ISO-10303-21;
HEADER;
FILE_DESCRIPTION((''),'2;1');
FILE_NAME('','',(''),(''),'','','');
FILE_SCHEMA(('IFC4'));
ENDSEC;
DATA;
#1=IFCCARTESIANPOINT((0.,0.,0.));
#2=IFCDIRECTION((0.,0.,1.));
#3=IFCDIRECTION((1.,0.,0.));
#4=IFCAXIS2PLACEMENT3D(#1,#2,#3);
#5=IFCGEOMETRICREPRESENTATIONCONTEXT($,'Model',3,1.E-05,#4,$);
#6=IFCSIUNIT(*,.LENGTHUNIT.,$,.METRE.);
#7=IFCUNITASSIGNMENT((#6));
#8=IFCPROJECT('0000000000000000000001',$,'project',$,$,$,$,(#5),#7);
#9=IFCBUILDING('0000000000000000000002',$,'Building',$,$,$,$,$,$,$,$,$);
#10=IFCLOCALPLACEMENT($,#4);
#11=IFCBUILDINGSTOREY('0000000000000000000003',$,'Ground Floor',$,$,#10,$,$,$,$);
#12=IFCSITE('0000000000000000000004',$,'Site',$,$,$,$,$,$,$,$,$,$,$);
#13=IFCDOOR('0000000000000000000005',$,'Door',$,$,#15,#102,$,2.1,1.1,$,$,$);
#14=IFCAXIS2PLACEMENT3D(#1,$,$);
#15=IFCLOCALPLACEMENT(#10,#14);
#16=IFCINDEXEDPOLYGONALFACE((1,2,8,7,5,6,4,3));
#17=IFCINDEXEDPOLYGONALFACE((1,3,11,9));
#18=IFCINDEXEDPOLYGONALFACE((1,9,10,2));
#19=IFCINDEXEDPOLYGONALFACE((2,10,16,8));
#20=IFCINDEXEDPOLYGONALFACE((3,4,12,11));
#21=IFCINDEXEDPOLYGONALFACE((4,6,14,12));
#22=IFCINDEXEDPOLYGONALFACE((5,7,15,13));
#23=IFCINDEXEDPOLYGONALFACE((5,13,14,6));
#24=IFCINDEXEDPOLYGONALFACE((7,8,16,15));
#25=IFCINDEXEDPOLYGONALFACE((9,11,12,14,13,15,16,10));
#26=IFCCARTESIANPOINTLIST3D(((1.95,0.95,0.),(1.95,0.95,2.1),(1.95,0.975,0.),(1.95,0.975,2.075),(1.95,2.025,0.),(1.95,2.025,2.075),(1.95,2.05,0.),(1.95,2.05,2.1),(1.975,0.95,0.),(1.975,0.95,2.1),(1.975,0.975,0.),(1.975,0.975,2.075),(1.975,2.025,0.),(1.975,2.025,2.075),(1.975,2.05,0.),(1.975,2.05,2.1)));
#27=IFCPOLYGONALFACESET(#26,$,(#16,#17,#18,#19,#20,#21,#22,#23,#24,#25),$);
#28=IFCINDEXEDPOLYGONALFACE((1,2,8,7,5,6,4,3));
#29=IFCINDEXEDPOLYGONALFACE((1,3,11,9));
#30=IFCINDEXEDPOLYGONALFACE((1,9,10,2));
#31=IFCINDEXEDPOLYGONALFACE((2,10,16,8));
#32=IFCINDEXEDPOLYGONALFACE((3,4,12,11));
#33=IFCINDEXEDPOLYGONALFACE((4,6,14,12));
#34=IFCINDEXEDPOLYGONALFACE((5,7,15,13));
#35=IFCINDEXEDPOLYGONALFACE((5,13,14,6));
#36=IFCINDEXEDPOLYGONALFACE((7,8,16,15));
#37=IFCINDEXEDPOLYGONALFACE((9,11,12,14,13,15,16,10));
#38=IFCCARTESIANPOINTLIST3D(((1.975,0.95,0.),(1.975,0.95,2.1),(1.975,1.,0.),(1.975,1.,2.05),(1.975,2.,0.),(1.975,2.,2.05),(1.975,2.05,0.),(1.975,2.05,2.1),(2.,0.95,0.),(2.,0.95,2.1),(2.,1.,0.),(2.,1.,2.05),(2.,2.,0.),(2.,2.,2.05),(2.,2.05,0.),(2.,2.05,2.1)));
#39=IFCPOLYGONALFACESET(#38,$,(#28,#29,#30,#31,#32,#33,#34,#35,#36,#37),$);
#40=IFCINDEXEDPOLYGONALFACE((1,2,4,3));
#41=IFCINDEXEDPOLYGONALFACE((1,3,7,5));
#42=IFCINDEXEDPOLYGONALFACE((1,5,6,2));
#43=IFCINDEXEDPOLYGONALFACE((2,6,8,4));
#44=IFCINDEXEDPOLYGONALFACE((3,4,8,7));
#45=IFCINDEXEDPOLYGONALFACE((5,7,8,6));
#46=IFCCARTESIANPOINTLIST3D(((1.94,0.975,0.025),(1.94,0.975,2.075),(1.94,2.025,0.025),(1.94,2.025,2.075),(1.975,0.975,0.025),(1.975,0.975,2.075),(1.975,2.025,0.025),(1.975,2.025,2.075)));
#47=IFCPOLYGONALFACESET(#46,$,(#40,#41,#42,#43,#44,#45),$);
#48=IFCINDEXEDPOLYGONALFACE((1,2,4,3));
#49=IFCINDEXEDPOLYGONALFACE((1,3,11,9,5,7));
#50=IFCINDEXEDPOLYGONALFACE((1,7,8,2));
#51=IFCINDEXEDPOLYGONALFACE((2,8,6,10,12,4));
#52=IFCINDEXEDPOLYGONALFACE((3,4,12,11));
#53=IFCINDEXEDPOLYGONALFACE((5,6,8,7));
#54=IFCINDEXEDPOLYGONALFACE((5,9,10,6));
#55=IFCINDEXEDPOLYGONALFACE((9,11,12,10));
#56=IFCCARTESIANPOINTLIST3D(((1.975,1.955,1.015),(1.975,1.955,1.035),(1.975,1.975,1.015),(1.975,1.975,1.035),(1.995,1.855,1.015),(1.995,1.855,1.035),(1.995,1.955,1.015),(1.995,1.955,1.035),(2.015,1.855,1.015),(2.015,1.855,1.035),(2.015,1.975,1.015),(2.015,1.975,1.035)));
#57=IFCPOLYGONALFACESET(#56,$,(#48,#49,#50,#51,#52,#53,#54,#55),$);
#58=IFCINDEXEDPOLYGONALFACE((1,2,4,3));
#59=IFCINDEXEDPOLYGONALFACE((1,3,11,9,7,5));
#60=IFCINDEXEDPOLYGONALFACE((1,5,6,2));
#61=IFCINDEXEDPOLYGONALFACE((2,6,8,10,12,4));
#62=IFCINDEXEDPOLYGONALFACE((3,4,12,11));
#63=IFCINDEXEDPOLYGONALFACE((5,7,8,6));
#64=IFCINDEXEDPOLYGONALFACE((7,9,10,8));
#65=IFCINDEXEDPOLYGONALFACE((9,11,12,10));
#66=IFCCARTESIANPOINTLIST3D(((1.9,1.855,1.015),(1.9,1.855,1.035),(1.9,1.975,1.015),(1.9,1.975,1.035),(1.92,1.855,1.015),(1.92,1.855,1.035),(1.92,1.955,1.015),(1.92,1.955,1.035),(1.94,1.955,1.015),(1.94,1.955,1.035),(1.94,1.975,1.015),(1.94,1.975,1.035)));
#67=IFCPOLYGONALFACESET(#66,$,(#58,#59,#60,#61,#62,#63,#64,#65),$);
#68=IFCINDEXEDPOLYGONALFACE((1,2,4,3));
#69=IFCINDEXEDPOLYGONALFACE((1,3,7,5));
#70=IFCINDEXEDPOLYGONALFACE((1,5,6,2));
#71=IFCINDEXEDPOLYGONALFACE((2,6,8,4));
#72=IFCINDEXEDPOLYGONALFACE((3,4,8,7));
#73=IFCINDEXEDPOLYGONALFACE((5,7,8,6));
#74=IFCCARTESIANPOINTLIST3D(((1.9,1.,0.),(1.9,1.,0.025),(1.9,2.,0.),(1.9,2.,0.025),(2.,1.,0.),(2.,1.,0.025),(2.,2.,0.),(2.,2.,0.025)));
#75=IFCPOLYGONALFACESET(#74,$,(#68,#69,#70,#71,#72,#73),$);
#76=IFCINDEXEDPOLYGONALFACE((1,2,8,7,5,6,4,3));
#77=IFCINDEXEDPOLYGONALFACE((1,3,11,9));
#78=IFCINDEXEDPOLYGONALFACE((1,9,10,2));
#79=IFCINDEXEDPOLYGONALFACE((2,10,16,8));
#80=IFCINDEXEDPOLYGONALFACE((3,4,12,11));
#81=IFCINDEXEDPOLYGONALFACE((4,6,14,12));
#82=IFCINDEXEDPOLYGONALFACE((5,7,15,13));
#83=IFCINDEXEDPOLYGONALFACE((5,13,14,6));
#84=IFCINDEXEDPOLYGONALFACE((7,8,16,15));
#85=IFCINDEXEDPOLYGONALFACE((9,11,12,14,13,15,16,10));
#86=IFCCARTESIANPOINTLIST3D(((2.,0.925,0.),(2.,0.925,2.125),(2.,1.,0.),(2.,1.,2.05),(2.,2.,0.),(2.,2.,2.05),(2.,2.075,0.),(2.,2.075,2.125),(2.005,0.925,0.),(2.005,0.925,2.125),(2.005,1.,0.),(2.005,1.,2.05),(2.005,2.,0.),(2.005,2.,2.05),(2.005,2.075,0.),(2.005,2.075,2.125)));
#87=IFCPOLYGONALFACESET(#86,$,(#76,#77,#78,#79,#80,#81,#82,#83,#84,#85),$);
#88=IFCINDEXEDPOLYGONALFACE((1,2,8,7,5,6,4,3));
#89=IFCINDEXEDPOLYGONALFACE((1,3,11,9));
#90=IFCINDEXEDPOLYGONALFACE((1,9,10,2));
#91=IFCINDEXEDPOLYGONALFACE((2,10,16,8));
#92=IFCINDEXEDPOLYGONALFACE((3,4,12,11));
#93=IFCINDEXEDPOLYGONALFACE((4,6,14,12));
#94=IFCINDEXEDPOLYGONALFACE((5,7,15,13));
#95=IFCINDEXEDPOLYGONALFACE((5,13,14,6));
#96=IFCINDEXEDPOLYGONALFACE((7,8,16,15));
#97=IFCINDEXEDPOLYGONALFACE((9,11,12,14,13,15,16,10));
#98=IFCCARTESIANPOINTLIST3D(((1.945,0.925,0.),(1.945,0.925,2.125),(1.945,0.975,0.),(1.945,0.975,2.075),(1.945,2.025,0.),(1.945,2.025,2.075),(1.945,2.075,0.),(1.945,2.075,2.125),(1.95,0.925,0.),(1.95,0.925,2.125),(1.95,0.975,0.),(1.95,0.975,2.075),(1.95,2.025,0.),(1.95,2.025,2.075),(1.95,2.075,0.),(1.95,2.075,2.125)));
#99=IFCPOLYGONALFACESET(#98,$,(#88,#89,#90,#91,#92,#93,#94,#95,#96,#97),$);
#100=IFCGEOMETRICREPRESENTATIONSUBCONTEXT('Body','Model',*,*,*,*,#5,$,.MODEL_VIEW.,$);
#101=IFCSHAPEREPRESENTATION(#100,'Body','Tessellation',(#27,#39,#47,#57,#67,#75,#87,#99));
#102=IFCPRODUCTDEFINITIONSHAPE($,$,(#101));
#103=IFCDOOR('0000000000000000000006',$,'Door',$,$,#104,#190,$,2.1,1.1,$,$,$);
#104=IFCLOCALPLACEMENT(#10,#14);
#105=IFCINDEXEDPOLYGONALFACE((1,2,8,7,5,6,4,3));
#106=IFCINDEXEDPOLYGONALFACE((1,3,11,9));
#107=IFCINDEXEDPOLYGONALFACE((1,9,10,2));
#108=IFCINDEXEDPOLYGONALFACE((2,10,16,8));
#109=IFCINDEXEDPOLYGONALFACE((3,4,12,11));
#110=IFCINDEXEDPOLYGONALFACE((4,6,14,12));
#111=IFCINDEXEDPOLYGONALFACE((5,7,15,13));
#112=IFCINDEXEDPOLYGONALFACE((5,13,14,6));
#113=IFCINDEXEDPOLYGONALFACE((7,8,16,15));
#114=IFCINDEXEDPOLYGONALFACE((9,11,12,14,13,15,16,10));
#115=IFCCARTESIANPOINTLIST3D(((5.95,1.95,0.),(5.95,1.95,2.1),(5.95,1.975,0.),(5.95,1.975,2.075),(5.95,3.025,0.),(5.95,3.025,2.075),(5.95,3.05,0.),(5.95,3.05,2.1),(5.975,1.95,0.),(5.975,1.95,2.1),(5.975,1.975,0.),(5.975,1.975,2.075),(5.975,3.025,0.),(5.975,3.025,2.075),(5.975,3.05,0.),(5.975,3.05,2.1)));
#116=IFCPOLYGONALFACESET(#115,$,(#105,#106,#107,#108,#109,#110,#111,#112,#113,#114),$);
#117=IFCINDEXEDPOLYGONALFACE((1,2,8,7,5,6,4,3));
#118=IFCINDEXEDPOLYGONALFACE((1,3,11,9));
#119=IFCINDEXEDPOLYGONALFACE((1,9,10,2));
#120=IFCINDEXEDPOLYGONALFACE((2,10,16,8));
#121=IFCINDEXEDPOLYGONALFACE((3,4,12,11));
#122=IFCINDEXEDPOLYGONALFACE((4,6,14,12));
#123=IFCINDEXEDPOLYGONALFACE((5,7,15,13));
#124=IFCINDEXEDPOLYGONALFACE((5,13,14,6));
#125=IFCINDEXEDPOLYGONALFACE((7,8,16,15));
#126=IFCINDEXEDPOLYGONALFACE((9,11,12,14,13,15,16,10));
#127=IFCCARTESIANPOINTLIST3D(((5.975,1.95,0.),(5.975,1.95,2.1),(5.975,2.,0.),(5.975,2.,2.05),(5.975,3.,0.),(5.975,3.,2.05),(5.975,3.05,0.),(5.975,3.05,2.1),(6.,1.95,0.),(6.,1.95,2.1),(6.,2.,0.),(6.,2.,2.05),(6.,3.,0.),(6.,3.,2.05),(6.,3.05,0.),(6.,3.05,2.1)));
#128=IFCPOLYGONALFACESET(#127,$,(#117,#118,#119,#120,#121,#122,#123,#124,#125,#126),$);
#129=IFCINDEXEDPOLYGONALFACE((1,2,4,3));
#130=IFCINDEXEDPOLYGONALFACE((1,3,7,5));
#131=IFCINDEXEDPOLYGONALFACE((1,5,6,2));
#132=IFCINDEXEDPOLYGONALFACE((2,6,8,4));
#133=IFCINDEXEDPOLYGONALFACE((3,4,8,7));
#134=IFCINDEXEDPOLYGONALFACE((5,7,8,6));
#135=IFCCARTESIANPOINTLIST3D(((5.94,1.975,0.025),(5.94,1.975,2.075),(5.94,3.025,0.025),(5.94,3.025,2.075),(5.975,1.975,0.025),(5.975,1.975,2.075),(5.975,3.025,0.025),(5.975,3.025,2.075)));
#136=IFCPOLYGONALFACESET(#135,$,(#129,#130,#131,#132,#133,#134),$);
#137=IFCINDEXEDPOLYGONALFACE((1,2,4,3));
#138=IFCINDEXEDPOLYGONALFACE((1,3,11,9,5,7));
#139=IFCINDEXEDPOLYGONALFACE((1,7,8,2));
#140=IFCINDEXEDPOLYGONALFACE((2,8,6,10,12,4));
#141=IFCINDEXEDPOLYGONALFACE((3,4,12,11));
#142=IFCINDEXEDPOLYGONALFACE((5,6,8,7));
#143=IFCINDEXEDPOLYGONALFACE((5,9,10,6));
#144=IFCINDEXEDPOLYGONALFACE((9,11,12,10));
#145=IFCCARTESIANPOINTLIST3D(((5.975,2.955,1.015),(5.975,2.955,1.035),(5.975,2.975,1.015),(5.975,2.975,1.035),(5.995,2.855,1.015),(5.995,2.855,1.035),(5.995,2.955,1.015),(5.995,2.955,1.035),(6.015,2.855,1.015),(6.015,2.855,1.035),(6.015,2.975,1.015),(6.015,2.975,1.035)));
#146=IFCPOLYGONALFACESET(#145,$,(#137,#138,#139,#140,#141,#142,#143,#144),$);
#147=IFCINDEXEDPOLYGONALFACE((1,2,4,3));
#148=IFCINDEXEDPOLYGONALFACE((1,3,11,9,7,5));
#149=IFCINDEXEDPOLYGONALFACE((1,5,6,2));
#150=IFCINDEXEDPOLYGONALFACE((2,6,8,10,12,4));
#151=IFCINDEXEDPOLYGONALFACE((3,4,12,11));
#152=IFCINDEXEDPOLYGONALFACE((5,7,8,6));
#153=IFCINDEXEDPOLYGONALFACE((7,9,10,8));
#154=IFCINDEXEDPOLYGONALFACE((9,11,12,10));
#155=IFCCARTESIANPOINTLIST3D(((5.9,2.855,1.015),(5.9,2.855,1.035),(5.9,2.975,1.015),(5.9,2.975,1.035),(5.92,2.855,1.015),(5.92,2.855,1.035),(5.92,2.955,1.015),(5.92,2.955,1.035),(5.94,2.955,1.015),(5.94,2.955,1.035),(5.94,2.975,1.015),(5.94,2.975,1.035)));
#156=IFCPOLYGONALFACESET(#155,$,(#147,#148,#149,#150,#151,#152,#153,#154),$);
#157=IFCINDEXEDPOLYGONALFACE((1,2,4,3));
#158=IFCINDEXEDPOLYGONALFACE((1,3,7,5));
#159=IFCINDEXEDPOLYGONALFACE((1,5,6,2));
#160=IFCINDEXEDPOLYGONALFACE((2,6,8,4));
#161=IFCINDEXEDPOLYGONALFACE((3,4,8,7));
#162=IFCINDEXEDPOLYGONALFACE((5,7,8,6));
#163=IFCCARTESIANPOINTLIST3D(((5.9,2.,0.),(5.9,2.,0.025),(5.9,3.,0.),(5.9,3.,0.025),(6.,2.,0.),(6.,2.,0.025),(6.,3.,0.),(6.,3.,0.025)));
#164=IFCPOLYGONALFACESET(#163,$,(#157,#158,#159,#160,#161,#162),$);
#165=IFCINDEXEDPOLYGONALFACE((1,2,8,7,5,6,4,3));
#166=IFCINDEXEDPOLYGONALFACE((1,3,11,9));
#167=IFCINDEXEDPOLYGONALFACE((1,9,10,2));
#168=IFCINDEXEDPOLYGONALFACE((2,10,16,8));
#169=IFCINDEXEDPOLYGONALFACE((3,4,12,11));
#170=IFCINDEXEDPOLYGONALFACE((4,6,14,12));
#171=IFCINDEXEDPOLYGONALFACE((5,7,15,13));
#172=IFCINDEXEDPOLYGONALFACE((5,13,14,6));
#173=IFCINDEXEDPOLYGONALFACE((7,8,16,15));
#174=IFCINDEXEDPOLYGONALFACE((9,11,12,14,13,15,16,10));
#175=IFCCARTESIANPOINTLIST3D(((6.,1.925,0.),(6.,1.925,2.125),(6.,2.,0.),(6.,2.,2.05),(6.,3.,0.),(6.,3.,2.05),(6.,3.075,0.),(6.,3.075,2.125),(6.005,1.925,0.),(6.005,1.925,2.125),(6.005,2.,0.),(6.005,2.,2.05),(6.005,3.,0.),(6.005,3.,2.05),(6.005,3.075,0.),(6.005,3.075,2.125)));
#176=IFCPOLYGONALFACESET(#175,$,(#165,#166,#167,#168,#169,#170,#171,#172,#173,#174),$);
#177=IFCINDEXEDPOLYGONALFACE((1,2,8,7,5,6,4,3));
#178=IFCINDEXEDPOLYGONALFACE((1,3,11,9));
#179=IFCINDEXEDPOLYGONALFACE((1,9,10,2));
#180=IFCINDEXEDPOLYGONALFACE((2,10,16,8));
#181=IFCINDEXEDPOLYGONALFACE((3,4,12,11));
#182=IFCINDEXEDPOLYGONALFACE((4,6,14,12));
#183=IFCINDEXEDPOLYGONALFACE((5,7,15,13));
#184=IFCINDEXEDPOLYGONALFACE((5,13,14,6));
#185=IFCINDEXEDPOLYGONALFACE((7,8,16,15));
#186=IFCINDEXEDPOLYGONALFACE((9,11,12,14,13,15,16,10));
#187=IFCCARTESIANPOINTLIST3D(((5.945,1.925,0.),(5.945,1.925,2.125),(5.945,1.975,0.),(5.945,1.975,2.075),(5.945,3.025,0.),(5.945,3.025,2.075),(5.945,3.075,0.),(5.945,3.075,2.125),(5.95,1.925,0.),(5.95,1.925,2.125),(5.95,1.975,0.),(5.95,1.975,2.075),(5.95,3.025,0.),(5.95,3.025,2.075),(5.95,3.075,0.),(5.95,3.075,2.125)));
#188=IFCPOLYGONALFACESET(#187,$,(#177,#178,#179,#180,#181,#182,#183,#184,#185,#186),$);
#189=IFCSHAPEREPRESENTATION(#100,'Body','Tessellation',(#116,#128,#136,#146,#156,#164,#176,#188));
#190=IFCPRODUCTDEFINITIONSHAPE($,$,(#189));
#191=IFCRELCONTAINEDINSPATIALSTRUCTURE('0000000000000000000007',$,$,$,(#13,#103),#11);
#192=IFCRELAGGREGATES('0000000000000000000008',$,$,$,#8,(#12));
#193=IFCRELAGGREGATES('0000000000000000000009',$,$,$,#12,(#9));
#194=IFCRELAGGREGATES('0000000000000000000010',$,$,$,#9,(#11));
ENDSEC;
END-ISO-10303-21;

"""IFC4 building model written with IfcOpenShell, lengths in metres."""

from ifc_helpers import new_model, si_unit, frame, origin_with_axes, place, context, subcontext, project, spatial, line, indexed_curve, outline, extrude, element, save


model = new_model("IFC4")

# Units and contexts
model_context = context("Model", 3, precision=1e-05, world=origin_with_axes())
body_context = subcontext(model_context, "Body", "Model", "MODEL_VIEW")
ifc_project = project(units=[si_unit("LENGTHUNIT", "METRE")], contexts=[model_context])

# Site, building, storey
site = spatial("IfcSite", under=ifc_project, Name="Site")
building = spatial("IfcBuilding", under=site, Name="Building")
storey_placement = place(None, origin_with_axes())
storey = spatial("IfcBuildingStorey", under=building, at=storey_placement, Name="Ground Floor")

# Doors
door_1_placement = place(storey_placement, frame((2.0, 0.95, 0.0), z_axis=(0.0, 0.0, 1.0), x_axis=(0.0, 1.0, 0.0)))
element("IfcDoor", 1, at=door_1_placement, inside=storey, Name="Door", OverallHeight=2.1, OverallWidth=1.1, context=body_context, shape_type="SweptSolid", body=[
    extrude(outline(indexed_curve([(0.0, 0.0), (0.0, 2.1), (1.1, 2.1), (1.1, 0.0), (1.075, 0.0), (1.075, 2.075), (0.025, 2.075), (0.025, 0.0)], segments=[line(1, 2, 3, 4, 5, 6, 7, 8, 1)])), frame((0.0, 0.025, 0.0), z_axis=(0.0, -1.0, 0.0), x_axis=(1.0, 0.0, 0.0)), (0.0, 0.0, -1.0), 0.025),
    extrude(outline(indexed_curve([(0.0, 0.0), (0.0, 2.1), (1.1, 2.1), (1.1, 0.0), (1.05, 0.0), (1.05, 2.05), (0.05, 2.05), (0.05, 0.0)], segments=[line(1, 2, 3, 4, 5, 6, 7, 8, 1)])), frame((0.0, 0.0, 0.0), z_axis=(0.0, -1.0, 0.0), x_axis=(1.0, 0.0, 0.0)), (0.0, 0.0, -1.0), 0.025),
    extrude(outline(indexed_curve([(0.0, 0.0), (1.05, 0.0), (1.05, 0.035), (0.0, 0.035)], segments=[line(1, 2, 3, 4, 1)])), frame((0.025, 0.025, 0.025), z_axis=(0.0, 0.0, 1.0), x_axis=(1.0, 0.0, 0.0)), (0.0, 0.0, 1.0), 2.05),
    extrude(outline(indexed_curve([(0.0, 0.0), (0.0, -0.04), (-0.12, -0.04), (-0.12, -0.02), (-0.02, -0.02), (-0.02, 0.0)], segments=[line(1, 2, 3, 4, 5, 6, 1)])), frame((1.025, 0.025, 1.015), z_axis=(0.0, 0.0, 1.0), x_axis=(1.0, 0.0, 0.0)), (0.0, 0.0, 1.0), 0.02),
    extrude(outline(indexed_curve([(0.0, 0.0), (0.0, 0.04), (-0.12, 0.04), (-0.12, 0.02), (-0.02, 0.02), (-0.02, 0.0)], segments=[line(1, 2, 3, 4, 5, 6, 1)])), frame((1.025, 0.06, 1.015), z_axis=(0.0, 0.0, 1.0), x_axis=(1.0, 0.0, 0.0)), (0.0, 0.0, 1.0), 0.02),
    extrude(outline(indexed_curve([(0.0, 0.0), (1.0, 0.0), (1.0, 0.1), (0.0, 0.1)], segments=[line(1, 2, 3, 4, 1)])), frame((0.05, 0.0, 0.0), z_axis=(0.0, 0.0, 1.0), x_axis=(1.0, 0.0, 0.0)), (0.0, 0.0, 1.0), 0.025),
    extrude(outline(indexed_curve([(0.0, 0.0), (0.0, 2.125), (1.15, 2.125), (1.15, 0.0), (1.075, 0.0), (1.075, 2.05), (0.075, 2.05), (0.075, 0.0)], segments=[line(1, 2, 3, 4, 5, 6, 7, 8, 1)])), frame((-0.025, -0.005, 0.0), z_axis=(0.0, -1.0, 0.0), x_axis=(1.0, 0.0, 0.0)), (0.0, 0.0, -1.0), 0.005),
    extrude(outline(indexed_curve([(0.0, 0.0), (0.0, 2.125), (1.15, 2.125), (1.15, 0.0), (1.1, 0.0), (1.1, 2.075), (0.05, 2.075), (0.05, 0.0)], segments=[line(1, 2, 3, 4, 5, 6, 7, 8, 1)])), frame((-0.025, 0.05, 0.0), z_axis=(0.0, -1.0, 0.0), x_axis=(1.0, 0.0, 0.0)), (0.0, 0.0, -1.0), 0.005),
])
door_2_placement = place(storey_placement, frame((6.0, 1.95, 0.0), z_axis=(0.0, 0.0, 1.0), x_axis=(0.0, 1.0, 0.0)))
element("IfcDoor", 2, at=door_2_placement, inside=storey, Name="Door", OverallHeight=2.1, OverallWidth=1.1, context=body_context, shape_type="SweptSolid", body=[
    extrude(outline(indexed_curve([(0.0, 0.0), (0.0, 2.1), (1.1, 2.1), (1.1, 0.0), (1.075, 0.0), (1.075, 2.075), (0.025, 2.075), (0.025, 0.0)], segments=[line(1, 2, 3, 4, 5, 6, 7, 8, 1)])), frame((0.0, 0.025, 0.0), z_axis=(0.0, -1.0, 0.0), x_axis=(1.0, 0.0, 0.0)), (0.0, 0.0, -1.0), 0.025),
    extrude(outline(indexed_curve([(0.0, 0.0), (0.0, 2.1), (1.1, 2.1), (1.1, 0.0), (1.05, 0.0), (1.05, 2.05), (0.05, 2.05), (0.05, 0.0)], segments=[line(1, 2, 3, 4, 5, 6, 7, 8, 1)])), frame((0.0, 0.0, 0.0), z_axis=(0.0, -1.0, 0.0), x_axis=(1.0, 0.0, 0.0)), (0.0, 0.0, -1.0), 0.025),
    extrude(outline(indexed_curve([(0.0, 0.0), (1.05, 0.0), (1.05, 0.035), (0.0, 0.035)], segments=[line(1, 2, 3, 4, 1)])), frame((0.025, 0.025, 0.025), z_axis=(0.0, 0.0, 1.0), x_axis=(1.0, 0.0, 0.0)), (0.0, 0.0, 1.0), 2.05),
    extrude(outline(indexed_curve([(0.0, 0.0), (0.0, -0.04), (-0.12, -0.04), (-0.12, -0.02), (-0.02, -0.02), (-0.02, 0.0)], segments=[line(1, 2, 3, 4, 5, 6, 1)])), frame((1.025, 0.025, 1.015), z_axis=(0.0, 0.0, 1.0), x_axis=(1.0, 0.0, 0.0)), (0.0, 0.0, 1.0), 0.02),
    extrude(outline(indexed_curve([(0.0, 0.0), (0.0, 0.04), (-0.12, 0.04), (-0.12, 0.02), (-0.02, 0.02), (-0.02, 0.0)], segments=[line(1, 2, 3, 4, 5, 6, 1)])), frame((1.025, 0.06, 1.015), z_axis=(0.0, 0.0, 1.0), x_axis=(1.0, 0.0, 0.0)), (0.0, 0.0, 1.0), 0.02),
    extrude(outline(indexed_curve([(0.0, 0.0), (1.0, 0.0), (1.0, 0.1), (0.0, 0.1)], segments=[line(1, 2, 3, 4, 1)])), frame((0.05, 0.0, 0.0), z_axis=(0.0, 0.0, 1.0), x_axis=(1.0, 0.0, 0.0)), (0.0, 0.0, 1.0), 0.025),
    extrude(outline(indexed_curve([(0.0, 0.0), (0.0, 2.125), (1.15, 2.125), (1.15, 0.0), (1.075, 0.0), (1.075, 2.05), (0.075, 2.05), (0.075, 0.0)], segments=[line(1, 2, 3, 4, 5, 6, 7, 8, 1)])), frame((-0.025, -0.005, 0.0), z_axis=(0.0, -1.0, 0.0), x_axis=(1.0, 0.0, 0.0)), (0.0, 0.0, -1.0), 0.005),
    extrude(outline(indexed_curve([(0.0, 0.0), (0.0, 2.125), (1.15, 2.125), (1.15, 0.0), (1.1, 0.0), (1.1, 2.075), (0.05, 2.075), (0.05, 0.0)], segments=[line(1, 2, 3, 4, 5, 6, 7, 8, 1)])), frame((-0.025, 0.05, 0.0), z_axis=(0.0, -1.0, 0.0), x_axis=(1.0, 0.0, 0.0)), (0.0, 0.0, -1.0), 0.005),
])

save(model, "model.ifc")
